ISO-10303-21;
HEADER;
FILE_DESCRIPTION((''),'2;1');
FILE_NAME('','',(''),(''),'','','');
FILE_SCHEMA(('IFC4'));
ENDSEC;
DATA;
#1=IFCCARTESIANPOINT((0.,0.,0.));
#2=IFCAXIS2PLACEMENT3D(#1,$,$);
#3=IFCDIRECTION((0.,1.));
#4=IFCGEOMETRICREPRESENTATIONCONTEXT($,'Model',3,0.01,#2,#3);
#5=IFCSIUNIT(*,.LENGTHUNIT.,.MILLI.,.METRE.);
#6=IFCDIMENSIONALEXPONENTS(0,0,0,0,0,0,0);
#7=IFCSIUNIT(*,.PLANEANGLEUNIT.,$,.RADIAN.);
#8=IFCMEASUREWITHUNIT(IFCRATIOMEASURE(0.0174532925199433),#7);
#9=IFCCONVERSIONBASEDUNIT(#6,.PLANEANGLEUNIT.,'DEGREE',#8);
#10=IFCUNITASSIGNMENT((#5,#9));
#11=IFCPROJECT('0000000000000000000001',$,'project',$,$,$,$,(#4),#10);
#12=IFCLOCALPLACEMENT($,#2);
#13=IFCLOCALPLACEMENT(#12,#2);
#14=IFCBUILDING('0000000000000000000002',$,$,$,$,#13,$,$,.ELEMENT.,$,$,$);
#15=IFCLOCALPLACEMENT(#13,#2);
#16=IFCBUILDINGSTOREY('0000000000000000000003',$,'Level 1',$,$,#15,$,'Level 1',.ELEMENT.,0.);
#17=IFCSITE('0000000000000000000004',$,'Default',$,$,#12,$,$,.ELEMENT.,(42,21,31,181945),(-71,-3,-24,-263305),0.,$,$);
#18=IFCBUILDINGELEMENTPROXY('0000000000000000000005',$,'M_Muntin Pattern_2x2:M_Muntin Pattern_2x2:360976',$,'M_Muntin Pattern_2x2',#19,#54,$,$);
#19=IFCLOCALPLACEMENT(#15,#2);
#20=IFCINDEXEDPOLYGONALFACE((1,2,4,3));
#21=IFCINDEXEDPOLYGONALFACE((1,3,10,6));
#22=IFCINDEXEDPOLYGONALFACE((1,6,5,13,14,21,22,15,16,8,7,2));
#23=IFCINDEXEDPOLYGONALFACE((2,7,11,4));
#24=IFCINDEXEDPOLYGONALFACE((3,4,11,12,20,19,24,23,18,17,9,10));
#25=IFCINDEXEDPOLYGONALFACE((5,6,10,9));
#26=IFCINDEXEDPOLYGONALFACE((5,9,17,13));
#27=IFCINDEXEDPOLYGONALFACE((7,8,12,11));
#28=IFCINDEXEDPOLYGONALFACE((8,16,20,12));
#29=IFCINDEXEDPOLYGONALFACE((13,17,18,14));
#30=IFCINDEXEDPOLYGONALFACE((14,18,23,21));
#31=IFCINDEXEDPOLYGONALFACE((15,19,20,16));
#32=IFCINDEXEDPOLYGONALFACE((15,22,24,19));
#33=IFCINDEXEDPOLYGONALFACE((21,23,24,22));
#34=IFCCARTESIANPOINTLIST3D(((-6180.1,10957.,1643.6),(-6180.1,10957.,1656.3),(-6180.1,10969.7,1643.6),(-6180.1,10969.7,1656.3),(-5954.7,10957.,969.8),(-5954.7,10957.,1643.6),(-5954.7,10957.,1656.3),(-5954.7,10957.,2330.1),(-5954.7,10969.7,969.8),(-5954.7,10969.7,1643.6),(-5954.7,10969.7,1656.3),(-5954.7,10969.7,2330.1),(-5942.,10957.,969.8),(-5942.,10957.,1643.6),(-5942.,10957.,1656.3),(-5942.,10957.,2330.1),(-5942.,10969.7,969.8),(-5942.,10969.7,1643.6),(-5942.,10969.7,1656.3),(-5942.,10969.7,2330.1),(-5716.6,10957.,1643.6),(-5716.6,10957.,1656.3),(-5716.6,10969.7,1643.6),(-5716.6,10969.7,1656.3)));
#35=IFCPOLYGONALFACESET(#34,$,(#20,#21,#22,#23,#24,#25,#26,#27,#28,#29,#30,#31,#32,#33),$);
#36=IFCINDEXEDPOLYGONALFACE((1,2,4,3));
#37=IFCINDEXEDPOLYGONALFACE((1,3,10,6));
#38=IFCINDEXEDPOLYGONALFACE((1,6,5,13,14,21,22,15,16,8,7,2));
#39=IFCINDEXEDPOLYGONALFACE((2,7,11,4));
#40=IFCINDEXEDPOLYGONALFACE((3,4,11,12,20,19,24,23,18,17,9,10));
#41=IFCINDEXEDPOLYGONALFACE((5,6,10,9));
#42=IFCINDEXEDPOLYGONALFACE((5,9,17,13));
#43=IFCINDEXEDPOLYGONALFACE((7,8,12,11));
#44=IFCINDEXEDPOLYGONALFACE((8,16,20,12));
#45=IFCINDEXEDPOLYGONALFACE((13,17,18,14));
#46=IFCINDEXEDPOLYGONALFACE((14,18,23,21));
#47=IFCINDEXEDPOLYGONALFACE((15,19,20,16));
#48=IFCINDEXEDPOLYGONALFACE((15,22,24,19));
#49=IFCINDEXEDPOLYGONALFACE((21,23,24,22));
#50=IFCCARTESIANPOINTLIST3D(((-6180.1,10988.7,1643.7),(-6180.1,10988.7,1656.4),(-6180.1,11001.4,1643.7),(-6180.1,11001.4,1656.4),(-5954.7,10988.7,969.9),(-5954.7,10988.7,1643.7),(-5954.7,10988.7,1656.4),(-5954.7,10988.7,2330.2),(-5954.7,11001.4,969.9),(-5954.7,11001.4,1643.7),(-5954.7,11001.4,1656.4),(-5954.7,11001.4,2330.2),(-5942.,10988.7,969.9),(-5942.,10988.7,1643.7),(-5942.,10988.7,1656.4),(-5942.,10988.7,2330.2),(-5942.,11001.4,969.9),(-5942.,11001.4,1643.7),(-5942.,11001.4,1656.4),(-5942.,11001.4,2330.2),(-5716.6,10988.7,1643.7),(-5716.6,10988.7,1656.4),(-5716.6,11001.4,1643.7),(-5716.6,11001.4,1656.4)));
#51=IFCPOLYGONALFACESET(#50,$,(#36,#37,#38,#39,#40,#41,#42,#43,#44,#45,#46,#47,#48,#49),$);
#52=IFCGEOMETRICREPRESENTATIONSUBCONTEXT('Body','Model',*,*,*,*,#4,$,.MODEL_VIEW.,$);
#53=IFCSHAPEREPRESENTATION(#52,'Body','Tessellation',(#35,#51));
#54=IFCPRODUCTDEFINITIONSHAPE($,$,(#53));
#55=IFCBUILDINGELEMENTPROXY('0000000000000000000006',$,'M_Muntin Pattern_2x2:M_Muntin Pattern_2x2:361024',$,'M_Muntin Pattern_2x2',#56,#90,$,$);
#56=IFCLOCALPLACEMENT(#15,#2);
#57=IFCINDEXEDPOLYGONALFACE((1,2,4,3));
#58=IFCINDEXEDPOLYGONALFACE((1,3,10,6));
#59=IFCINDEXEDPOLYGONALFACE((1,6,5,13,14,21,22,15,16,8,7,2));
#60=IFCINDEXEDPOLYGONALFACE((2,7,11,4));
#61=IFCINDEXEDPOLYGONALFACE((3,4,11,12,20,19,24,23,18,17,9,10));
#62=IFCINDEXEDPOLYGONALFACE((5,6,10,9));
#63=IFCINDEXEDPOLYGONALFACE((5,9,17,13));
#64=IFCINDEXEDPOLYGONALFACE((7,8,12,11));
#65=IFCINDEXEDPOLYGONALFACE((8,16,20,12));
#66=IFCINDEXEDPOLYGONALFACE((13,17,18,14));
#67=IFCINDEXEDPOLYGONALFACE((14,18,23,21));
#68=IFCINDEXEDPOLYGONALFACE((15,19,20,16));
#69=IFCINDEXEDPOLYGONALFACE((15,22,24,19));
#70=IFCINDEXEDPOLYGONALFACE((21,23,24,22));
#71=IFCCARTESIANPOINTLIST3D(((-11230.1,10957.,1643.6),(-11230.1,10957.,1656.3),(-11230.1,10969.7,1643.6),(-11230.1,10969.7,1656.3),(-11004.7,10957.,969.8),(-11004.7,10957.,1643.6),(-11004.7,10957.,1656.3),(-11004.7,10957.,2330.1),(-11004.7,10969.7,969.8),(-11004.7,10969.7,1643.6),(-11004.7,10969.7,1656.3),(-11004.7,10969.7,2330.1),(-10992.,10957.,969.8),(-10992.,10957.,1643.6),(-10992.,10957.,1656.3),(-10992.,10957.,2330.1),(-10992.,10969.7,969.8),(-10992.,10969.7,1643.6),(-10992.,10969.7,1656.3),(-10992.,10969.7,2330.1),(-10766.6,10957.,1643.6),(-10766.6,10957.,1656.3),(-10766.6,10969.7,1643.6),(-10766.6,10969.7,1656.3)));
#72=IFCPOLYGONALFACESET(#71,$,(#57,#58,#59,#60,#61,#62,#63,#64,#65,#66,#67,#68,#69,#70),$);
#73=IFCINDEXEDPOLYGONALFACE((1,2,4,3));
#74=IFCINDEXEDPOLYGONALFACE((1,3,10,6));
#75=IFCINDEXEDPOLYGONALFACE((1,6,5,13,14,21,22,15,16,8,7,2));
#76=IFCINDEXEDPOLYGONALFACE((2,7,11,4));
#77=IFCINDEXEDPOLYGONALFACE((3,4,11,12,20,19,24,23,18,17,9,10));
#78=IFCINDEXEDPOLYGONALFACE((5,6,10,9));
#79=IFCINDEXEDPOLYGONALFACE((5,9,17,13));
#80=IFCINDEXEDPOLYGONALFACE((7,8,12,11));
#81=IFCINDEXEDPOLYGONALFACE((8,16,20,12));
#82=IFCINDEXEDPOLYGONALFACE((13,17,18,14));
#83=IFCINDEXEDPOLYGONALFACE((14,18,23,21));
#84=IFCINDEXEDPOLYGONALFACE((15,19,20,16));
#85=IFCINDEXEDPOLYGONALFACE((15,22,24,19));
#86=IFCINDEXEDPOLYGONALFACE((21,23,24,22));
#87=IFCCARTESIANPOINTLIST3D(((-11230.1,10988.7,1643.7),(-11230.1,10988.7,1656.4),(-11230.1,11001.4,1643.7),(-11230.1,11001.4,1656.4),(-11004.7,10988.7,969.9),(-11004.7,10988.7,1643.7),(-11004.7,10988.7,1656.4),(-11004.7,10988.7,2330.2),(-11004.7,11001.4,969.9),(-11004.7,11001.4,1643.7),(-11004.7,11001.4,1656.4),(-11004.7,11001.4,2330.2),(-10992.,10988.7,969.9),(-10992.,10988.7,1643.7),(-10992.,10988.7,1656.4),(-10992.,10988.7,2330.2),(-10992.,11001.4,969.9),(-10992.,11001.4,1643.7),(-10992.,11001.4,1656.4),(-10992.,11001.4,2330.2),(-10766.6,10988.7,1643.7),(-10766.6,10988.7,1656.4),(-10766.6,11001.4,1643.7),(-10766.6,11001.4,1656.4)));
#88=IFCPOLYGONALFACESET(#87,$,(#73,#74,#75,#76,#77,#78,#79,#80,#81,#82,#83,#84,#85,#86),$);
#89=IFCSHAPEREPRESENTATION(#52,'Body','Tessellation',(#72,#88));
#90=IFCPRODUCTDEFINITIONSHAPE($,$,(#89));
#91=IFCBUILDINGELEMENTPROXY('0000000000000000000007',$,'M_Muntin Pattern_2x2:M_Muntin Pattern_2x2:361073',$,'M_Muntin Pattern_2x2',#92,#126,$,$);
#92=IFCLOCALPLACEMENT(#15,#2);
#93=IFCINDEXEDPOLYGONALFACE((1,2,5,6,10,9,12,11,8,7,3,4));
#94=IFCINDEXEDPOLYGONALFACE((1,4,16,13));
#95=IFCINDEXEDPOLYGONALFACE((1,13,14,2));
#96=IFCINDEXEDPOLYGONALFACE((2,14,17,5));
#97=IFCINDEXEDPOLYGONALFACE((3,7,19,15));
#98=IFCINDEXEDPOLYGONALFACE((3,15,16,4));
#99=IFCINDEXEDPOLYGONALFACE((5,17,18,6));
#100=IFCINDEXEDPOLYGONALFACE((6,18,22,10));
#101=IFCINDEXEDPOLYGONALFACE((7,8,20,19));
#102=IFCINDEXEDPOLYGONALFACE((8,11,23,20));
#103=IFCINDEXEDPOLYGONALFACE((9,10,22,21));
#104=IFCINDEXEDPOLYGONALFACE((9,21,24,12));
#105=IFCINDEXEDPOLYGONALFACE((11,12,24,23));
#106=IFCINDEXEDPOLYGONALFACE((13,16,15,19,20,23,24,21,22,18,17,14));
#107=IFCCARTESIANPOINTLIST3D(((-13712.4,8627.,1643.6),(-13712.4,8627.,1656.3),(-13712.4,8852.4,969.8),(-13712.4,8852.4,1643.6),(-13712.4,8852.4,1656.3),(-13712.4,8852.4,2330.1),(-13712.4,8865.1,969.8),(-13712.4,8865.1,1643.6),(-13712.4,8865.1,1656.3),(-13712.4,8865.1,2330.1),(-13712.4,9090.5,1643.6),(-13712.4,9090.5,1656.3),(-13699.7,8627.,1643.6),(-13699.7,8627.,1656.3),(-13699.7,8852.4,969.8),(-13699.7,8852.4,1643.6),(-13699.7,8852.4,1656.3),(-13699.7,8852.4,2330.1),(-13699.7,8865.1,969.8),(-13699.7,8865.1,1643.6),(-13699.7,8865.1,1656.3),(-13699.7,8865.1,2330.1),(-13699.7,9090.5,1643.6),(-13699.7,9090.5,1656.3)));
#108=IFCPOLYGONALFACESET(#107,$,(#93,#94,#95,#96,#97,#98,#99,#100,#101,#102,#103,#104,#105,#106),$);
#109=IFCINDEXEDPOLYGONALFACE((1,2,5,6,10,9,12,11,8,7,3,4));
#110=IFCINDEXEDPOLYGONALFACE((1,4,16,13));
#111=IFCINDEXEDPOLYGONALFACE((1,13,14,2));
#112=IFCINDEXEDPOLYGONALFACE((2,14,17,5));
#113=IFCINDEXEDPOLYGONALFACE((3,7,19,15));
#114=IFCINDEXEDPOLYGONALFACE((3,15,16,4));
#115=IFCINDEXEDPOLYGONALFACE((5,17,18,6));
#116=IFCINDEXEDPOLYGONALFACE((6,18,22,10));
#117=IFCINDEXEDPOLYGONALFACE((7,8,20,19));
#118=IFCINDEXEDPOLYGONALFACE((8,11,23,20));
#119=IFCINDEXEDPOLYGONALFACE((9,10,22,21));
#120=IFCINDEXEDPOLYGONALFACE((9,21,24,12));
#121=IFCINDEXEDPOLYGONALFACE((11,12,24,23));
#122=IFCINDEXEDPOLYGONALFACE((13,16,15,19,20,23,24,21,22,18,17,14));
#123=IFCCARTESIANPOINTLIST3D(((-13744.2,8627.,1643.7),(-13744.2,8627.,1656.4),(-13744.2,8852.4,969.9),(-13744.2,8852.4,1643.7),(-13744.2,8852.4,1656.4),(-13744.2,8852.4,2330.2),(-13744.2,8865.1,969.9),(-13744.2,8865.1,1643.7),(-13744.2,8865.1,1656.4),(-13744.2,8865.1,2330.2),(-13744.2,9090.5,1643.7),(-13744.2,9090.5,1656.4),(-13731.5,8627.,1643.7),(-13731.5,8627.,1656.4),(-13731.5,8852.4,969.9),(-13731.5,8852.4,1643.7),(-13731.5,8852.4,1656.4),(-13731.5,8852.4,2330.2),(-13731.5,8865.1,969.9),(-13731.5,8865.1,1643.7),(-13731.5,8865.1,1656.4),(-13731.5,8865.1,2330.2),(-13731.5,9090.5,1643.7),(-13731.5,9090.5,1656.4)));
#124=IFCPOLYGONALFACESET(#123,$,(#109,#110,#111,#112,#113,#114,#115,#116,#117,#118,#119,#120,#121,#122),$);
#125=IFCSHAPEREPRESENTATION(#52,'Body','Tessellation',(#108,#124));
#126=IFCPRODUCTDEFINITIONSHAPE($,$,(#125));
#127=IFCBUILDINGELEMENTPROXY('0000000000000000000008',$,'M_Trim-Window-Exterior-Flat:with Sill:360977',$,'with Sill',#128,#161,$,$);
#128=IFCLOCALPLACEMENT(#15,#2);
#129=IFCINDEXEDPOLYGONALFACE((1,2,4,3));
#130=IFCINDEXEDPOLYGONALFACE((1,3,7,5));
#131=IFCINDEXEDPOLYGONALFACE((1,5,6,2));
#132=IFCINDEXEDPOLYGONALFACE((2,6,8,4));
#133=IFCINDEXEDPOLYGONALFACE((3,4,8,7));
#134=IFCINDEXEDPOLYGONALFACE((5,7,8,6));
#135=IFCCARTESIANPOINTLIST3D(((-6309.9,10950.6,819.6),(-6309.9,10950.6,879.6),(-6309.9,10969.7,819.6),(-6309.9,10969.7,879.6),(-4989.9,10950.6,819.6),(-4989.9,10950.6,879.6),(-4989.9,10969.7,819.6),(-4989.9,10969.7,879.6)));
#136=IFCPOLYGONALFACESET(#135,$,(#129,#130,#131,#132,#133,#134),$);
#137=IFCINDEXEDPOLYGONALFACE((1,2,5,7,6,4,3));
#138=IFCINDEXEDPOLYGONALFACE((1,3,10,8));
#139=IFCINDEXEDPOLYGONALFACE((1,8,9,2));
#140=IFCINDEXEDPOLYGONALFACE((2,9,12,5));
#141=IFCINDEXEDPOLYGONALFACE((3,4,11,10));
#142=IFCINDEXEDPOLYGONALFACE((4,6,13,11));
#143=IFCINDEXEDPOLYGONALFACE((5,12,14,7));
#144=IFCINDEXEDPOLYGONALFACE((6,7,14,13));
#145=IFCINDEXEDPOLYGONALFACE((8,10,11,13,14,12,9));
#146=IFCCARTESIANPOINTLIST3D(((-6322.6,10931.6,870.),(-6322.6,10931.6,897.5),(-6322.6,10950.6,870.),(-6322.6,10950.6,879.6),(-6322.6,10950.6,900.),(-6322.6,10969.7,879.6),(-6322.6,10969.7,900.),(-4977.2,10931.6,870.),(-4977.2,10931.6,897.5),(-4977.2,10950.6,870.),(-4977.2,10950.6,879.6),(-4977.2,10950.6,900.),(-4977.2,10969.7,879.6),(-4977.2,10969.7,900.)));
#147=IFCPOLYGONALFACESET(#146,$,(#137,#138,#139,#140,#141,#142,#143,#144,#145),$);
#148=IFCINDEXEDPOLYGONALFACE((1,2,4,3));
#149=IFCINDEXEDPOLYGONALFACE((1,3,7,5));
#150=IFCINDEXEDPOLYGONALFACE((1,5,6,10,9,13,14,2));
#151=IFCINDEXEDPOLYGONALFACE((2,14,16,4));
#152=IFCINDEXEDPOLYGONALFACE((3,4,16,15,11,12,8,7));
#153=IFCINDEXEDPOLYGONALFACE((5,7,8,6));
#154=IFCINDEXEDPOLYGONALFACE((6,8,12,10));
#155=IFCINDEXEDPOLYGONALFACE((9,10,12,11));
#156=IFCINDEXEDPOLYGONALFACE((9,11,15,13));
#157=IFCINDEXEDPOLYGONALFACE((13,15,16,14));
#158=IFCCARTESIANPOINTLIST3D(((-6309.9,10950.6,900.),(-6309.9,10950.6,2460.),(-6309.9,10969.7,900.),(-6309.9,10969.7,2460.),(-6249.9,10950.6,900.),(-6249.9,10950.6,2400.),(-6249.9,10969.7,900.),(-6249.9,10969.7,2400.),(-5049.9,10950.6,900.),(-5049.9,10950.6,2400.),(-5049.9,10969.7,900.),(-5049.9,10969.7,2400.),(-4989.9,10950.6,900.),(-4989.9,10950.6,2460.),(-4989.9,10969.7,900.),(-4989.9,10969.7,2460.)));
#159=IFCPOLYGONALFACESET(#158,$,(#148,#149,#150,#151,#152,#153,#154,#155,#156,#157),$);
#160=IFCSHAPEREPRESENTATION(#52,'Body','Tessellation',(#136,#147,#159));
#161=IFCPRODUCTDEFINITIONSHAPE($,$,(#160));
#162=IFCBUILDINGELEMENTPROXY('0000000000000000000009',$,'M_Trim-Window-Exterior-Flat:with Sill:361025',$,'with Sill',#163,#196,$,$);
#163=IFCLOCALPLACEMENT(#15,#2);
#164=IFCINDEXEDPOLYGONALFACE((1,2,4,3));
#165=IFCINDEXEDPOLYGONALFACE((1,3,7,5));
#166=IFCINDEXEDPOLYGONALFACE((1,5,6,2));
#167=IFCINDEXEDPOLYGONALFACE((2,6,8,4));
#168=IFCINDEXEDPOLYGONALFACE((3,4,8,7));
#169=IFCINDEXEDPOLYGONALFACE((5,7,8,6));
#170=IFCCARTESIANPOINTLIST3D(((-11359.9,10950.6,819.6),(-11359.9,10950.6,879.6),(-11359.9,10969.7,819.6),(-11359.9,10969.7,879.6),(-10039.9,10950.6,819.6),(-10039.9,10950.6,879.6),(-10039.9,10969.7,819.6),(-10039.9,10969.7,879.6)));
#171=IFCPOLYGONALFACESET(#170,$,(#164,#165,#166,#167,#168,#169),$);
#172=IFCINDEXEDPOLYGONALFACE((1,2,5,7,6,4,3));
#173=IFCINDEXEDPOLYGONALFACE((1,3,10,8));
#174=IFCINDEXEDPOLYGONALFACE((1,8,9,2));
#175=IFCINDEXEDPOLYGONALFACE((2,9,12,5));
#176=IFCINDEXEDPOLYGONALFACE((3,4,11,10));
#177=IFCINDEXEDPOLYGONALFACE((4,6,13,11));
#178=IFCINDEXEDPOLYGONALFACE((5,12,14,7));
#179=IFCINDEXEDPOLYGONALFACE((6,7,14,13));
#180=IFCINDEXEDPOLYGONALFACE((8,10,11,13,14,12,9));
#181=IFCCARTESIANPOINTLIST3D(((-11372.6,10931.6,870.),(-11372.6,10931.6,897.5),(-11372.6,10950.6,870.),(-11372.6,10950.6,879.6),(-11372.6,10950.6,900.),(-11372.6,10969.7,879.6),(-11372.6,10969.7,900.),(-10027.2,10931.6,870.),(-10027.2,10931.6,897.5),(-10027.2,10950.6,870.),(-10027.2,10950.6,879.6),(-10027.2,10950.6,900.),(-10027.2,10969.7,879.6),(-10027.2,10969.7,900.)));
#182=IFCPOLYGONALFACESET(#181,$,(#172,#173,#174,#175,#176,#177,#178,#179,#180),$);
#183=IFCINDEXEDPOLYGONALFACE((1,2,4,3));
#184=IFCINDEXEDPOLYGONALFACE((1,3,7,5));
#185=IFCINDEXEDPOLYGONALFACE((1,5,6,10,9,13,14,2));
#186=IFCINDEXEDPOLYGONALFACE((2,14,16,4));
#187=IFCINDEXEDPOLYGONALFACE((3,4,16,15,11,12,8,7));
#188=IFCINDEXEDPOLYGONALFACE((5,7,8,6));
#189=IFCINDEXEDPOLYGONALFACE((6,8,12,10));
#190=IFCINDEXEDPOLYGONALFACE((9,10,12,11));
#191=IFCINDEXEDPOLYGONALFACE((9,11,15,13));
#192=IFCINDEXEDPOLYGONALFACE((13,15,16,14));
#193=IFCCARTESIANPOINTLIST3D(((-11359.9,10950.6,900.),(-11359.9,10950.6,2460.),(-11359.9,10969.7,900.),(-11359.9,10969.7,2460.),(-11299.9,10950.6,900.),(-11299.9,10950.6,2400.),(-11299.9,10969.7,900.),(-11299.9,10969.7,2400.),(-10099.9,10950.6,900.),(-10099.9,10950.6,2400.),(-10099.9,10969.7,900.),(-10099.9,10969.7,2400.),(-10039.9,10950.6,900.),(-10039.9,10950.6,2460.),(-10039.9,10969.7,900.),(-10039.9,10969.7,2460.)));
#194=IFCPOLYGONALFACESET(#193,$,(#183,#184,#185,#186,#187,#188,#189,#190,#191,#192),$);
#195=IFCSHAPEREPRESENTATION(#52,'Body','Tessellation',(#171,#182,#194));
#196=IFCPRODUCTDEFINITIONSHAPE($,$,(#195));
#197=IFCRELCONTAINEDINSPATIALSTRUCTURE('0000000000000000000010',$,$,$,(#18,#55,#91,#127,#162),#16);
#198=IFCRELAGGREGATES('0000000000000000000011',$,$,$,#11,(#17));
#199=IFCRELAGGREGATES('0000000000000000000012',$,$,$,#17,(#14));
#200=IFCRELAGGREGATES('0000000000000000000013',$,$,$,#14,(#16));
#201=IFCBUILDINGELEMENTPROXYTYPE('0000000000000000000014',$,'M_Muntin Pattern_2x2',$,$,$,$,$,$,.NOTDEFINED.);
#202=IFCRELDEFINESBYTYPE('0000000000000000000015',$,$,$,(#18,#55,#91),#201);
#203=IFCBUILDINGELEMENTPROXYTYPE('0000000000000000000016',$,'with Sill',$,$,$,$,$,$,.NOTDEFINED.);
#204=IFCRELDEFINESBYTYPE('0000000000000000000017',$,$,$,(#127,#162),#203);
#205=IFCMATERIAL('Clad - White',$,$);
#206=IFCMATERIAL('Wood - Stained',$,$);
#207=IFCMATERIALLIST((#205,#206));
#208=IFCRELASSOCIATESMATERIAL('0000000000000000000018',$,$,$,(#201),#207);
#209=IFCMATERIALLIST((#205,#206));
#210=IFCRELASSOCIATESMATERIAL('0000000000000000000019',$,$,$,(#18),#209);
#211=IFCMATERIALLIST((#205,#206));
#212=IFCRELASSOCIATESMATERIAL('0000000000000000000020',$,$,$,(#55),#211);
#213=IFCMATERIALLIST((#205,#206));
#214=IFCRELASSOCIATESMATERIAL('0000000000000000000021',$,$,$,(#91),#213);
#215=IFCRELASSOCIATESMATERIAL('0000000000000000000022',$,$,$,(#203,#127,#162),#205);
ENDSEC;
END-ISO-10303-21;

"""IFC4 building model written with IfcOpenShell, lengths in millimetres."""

from ifc_helpers import new_model, entity, si_unit, converted_unit, direction, frame, frame_2d, origin, place, context, subcontext, project, spatial, polyline, rectangle, outline, extrude, source, transform, mapped, material, material_list, type_object, type_shapes, element, save


model = new_model("IFC4")

# Units and contexts
model_context = context("Model", 3, precision=0.01, world=origin(), true_north=direction((0.0, 1.0)))
body_context = subcontext(model_context, "Body", "Model", "MODEL_VIEW")
ifc_project = project(units=[si_unit("LENGTHUNIT", "METRE", prefix="MILLI"), converted_unit("PLANEANGLEUNIT", "DEGREE", entity("IfcRatioMeasure", 0.0174532925199433), si_unit("PLANEANGLEUNIT", "RADIAN"), dimensions=[0, 0, 0, 0, 0, 0, 0])], contexts=[model_context])

# Site, building, storey
site_placement = place(None, origin())
site = spatial("IfcSite", under=ifc_project, at=site_placement, Name="Default", CompositionType="ELEMENT", RefLatitude=(42, 21, 31, 181945), RefLongitude=(-71, -3, -24, -263305), RefElevation=0.0)
building_placement = place(site_placement, origin())
building = spatial("IfcBuilding", under=site, at=building_placement, CompositionType="ELEMENT")
storey_placement = place(building_placement, origin())
storey = spatial("IfcBuildingStorey", under=building, at=storey_placement, Name="Level 1", LongName="Level 1", CompositionType="ELEMENT", Elevation=0.0)

# Building element proxies
ifc_material_1 = material(Name="Clad - White")
ifc_material_2 = material(Name="Wood - Stained")
ifc_material_list_1 = material_list([ifc_material_1, ifc_material_2])
ifc_material_list_2 = material_list([ifc_material_1, ifc_material_2])
building_element_proxy_type_1 = type_object("IfcBuildingElementProxyType", Name="M_Muntin Pattern_2x2", PredefinedType="NOTDEFINED", material=ifc_material_list_2)
shared_shape_1 = source(origin(), body_context, "Body", "SweptSolid", [
    extrude(outline(polyline([(6.4, -6.4), (680.1, -6.4), (680.1, 6.3), (6.4, 6.3), (6.4, 231.7), (-6.3, 231.7), (-6.3, 6.3), (-680.2, 6.3), (-680.2, -6.4), (-6.3, -6.4), (-6.3, -231.7), (6.4, -231.7), (6.4, -6.4)])), frame((0.0, -22.2, 680.1), z_axis=(0.0, 1.0, 0.0), x_axis=(0.0, 0.0, 1.0)), (0.0, 0.0, 1.0), 12.7),
    extrude(outline(polyline([(6.4, -6.4), (680.1, -6.4), (680.1, 6.3), (6.4, 6.3), (6.4, 231.7), (-6.3, 231.7), (-6.3, 6.3), (-680.2, 6.3), (-680.2, -6.4), (-6.3, -6.4), (-6.3, -231.7), (6.4, -231.7), (6.4, -6.4)])), frame((0.0, 9.5, 680.2), z_axis=(0.0, 1.0, 0.0), x_axis=(0.0, 0.0, 1.0)), (0.0, 0.0, 1.0), 12.7),
])
type_shapes(building_element_proxy_type_1, [shared_shape_1])
proxy_1_placement = place(storey_placement, frame((-5948.4, 10979.2, 969.9)))
element("IfcBuildingElementProxy", 1, at=proxy_1_placement, inside=storey, type_object=building_element_proxy_type_1, material=ifc_material_list_1, Name="M_Muntin Pattern_2x2:M_Muntin Pattern_2x2:360976", ObjectType="M_Muntin Pattern_2x2", context=body_context, shape_type="MappedRepresentation", body=[
    mapped(shared_shape_1, transform((0.0, 0.0, 0.0), scale=1.0)),
])
ifc_material_list_3 = material_list([ifc_material_1, ifc_material_2])
proxy_2_placement = place(storey_placement, frame((-10998.4, 10979.2, 969.9)))
element("IfcBuildingElementProxy", 2, at=proxy_2_placement, inside=storey, type_object=building_element_proxy_type_1, material=ifc_material_list_3, Name="M_Muntin Pattern_2x2:M_Muntin Pattern_2x2:361024", ObjectType="M_Muntin Pattern_2x2", context=body_context, shape_type="MappedRepresentation", body=[
    mapped(shared_shape_1, transform((0.0, 0.0, 0.0), scale=1.0)),
])
ifc_material_list_4 = material_list([ifc_material_1, ifc_material_2])
proxy_3_placement = place(storey_placement, frame((-13722.0, 8858.7, 969.9), z_axis=(0.0, 0.0, 1.0), x_axis=(0.0, 1.0, 0.0)))
element("IfcBuildingElementProxy", 3, at=proxy_3_placement, inside=storey, type_object=building_element_proxy_type_1, material=ifc_material_list_4, Name="M_Muntin Pattern_2x2:M_Muntin Pattern_2x2:361073", ObjectType="M_Muntin Pattern_2x2", context=body_context, shape_type="MappedRepresentation", body=[
    mapped(shared_shape_1, transform((0.0, 0.0, 0.0), scale=1.0)),
])
building_element_proxy_type_2 = type_object("IfcBuildingElementProxyType", Name="with Sill", PredefinedType="NOTDEFINED", material=ifc_material_1)
shared_shape_2 = source(origin(), body_context, "Body", "SweptSolid", [
    extrude(rectangle(XDim=1320.0, YDim=60.0, at=frame_2d((0.0, 0.0), x_axis=(1.0, 0.0))), frame((0.0, -1550.4, 0.0), z_axis=(0.0, 0.0, 1.0), x_axis=(-1.0, 0.0, 0.0)), (0.0, 0.0, 1.0), 19.1),
    extrude(outline(polyline([(-19.0, -15.2), (0.0, -15.2), (0.0, -5.7), (19.0, -5.7), (19.0, 14.8), (0.0, 14.8), (-19.0, 12.3), (-19.0, -15.2)])), frame((-672.7, -1514.8, 19.0), z_axis=(1.0, 0.0, 0.0), x_axis=(0.0, 0.0, -1.0)), (0.0, 0.0, 1.0), 1345.4),
    extrude(outline(polyline([(-795.0, -660.0), (765.0, -660.0), (765.0, -600.0), (-735.0, -600.0), (-735.0, 600.0), (765.0, 600.0), (765.0, 660.0), (-795.0, 660.0), (-795.0, -660.0)])), frame((0.0, -735.0, 0.0), z_axis=(0.0, 0.0, 1.0), x_axis=(0.0, -1.0, 0.0)), (0.0, 0.0, 1.0), 19.1),
])
type_shapes(building_element_proxy_type_2, [shared_shape_2])
for number, where, z_axis, x_axis, name in (
    (4, (-5649.9, 10969.7, 2400.0), (0.0, -1.0, 0.0), (1.0, 0.0, 0.0), "M_Trim-Window-Exterior-Flat:with Sill:360977"),
    (5, (-10699.9, 10969.7, 2400.0), (0.0, -1.0, 0.0), (1.0, 0.0, 0.0), "M_Trim-Window-Exterior-Flat:with Sill:361025"),
):
    element("IfcBuildingElementProxy", number, at=place(storey_placement, frame(where, z_axis=z_axis, x_axis=x_axis)), inside=storey, type_object=building_element_proxy_type_2, material=ifc_material_1, Name=name, ObjectType="with Sill", context=body_context, shape_type="MappedRepresentation", body=[
        mapped(shared_shape_2, transform((0.0, 0.0, 0.0), scale=1.0)),
    ])

save(model, "model.ifc")
